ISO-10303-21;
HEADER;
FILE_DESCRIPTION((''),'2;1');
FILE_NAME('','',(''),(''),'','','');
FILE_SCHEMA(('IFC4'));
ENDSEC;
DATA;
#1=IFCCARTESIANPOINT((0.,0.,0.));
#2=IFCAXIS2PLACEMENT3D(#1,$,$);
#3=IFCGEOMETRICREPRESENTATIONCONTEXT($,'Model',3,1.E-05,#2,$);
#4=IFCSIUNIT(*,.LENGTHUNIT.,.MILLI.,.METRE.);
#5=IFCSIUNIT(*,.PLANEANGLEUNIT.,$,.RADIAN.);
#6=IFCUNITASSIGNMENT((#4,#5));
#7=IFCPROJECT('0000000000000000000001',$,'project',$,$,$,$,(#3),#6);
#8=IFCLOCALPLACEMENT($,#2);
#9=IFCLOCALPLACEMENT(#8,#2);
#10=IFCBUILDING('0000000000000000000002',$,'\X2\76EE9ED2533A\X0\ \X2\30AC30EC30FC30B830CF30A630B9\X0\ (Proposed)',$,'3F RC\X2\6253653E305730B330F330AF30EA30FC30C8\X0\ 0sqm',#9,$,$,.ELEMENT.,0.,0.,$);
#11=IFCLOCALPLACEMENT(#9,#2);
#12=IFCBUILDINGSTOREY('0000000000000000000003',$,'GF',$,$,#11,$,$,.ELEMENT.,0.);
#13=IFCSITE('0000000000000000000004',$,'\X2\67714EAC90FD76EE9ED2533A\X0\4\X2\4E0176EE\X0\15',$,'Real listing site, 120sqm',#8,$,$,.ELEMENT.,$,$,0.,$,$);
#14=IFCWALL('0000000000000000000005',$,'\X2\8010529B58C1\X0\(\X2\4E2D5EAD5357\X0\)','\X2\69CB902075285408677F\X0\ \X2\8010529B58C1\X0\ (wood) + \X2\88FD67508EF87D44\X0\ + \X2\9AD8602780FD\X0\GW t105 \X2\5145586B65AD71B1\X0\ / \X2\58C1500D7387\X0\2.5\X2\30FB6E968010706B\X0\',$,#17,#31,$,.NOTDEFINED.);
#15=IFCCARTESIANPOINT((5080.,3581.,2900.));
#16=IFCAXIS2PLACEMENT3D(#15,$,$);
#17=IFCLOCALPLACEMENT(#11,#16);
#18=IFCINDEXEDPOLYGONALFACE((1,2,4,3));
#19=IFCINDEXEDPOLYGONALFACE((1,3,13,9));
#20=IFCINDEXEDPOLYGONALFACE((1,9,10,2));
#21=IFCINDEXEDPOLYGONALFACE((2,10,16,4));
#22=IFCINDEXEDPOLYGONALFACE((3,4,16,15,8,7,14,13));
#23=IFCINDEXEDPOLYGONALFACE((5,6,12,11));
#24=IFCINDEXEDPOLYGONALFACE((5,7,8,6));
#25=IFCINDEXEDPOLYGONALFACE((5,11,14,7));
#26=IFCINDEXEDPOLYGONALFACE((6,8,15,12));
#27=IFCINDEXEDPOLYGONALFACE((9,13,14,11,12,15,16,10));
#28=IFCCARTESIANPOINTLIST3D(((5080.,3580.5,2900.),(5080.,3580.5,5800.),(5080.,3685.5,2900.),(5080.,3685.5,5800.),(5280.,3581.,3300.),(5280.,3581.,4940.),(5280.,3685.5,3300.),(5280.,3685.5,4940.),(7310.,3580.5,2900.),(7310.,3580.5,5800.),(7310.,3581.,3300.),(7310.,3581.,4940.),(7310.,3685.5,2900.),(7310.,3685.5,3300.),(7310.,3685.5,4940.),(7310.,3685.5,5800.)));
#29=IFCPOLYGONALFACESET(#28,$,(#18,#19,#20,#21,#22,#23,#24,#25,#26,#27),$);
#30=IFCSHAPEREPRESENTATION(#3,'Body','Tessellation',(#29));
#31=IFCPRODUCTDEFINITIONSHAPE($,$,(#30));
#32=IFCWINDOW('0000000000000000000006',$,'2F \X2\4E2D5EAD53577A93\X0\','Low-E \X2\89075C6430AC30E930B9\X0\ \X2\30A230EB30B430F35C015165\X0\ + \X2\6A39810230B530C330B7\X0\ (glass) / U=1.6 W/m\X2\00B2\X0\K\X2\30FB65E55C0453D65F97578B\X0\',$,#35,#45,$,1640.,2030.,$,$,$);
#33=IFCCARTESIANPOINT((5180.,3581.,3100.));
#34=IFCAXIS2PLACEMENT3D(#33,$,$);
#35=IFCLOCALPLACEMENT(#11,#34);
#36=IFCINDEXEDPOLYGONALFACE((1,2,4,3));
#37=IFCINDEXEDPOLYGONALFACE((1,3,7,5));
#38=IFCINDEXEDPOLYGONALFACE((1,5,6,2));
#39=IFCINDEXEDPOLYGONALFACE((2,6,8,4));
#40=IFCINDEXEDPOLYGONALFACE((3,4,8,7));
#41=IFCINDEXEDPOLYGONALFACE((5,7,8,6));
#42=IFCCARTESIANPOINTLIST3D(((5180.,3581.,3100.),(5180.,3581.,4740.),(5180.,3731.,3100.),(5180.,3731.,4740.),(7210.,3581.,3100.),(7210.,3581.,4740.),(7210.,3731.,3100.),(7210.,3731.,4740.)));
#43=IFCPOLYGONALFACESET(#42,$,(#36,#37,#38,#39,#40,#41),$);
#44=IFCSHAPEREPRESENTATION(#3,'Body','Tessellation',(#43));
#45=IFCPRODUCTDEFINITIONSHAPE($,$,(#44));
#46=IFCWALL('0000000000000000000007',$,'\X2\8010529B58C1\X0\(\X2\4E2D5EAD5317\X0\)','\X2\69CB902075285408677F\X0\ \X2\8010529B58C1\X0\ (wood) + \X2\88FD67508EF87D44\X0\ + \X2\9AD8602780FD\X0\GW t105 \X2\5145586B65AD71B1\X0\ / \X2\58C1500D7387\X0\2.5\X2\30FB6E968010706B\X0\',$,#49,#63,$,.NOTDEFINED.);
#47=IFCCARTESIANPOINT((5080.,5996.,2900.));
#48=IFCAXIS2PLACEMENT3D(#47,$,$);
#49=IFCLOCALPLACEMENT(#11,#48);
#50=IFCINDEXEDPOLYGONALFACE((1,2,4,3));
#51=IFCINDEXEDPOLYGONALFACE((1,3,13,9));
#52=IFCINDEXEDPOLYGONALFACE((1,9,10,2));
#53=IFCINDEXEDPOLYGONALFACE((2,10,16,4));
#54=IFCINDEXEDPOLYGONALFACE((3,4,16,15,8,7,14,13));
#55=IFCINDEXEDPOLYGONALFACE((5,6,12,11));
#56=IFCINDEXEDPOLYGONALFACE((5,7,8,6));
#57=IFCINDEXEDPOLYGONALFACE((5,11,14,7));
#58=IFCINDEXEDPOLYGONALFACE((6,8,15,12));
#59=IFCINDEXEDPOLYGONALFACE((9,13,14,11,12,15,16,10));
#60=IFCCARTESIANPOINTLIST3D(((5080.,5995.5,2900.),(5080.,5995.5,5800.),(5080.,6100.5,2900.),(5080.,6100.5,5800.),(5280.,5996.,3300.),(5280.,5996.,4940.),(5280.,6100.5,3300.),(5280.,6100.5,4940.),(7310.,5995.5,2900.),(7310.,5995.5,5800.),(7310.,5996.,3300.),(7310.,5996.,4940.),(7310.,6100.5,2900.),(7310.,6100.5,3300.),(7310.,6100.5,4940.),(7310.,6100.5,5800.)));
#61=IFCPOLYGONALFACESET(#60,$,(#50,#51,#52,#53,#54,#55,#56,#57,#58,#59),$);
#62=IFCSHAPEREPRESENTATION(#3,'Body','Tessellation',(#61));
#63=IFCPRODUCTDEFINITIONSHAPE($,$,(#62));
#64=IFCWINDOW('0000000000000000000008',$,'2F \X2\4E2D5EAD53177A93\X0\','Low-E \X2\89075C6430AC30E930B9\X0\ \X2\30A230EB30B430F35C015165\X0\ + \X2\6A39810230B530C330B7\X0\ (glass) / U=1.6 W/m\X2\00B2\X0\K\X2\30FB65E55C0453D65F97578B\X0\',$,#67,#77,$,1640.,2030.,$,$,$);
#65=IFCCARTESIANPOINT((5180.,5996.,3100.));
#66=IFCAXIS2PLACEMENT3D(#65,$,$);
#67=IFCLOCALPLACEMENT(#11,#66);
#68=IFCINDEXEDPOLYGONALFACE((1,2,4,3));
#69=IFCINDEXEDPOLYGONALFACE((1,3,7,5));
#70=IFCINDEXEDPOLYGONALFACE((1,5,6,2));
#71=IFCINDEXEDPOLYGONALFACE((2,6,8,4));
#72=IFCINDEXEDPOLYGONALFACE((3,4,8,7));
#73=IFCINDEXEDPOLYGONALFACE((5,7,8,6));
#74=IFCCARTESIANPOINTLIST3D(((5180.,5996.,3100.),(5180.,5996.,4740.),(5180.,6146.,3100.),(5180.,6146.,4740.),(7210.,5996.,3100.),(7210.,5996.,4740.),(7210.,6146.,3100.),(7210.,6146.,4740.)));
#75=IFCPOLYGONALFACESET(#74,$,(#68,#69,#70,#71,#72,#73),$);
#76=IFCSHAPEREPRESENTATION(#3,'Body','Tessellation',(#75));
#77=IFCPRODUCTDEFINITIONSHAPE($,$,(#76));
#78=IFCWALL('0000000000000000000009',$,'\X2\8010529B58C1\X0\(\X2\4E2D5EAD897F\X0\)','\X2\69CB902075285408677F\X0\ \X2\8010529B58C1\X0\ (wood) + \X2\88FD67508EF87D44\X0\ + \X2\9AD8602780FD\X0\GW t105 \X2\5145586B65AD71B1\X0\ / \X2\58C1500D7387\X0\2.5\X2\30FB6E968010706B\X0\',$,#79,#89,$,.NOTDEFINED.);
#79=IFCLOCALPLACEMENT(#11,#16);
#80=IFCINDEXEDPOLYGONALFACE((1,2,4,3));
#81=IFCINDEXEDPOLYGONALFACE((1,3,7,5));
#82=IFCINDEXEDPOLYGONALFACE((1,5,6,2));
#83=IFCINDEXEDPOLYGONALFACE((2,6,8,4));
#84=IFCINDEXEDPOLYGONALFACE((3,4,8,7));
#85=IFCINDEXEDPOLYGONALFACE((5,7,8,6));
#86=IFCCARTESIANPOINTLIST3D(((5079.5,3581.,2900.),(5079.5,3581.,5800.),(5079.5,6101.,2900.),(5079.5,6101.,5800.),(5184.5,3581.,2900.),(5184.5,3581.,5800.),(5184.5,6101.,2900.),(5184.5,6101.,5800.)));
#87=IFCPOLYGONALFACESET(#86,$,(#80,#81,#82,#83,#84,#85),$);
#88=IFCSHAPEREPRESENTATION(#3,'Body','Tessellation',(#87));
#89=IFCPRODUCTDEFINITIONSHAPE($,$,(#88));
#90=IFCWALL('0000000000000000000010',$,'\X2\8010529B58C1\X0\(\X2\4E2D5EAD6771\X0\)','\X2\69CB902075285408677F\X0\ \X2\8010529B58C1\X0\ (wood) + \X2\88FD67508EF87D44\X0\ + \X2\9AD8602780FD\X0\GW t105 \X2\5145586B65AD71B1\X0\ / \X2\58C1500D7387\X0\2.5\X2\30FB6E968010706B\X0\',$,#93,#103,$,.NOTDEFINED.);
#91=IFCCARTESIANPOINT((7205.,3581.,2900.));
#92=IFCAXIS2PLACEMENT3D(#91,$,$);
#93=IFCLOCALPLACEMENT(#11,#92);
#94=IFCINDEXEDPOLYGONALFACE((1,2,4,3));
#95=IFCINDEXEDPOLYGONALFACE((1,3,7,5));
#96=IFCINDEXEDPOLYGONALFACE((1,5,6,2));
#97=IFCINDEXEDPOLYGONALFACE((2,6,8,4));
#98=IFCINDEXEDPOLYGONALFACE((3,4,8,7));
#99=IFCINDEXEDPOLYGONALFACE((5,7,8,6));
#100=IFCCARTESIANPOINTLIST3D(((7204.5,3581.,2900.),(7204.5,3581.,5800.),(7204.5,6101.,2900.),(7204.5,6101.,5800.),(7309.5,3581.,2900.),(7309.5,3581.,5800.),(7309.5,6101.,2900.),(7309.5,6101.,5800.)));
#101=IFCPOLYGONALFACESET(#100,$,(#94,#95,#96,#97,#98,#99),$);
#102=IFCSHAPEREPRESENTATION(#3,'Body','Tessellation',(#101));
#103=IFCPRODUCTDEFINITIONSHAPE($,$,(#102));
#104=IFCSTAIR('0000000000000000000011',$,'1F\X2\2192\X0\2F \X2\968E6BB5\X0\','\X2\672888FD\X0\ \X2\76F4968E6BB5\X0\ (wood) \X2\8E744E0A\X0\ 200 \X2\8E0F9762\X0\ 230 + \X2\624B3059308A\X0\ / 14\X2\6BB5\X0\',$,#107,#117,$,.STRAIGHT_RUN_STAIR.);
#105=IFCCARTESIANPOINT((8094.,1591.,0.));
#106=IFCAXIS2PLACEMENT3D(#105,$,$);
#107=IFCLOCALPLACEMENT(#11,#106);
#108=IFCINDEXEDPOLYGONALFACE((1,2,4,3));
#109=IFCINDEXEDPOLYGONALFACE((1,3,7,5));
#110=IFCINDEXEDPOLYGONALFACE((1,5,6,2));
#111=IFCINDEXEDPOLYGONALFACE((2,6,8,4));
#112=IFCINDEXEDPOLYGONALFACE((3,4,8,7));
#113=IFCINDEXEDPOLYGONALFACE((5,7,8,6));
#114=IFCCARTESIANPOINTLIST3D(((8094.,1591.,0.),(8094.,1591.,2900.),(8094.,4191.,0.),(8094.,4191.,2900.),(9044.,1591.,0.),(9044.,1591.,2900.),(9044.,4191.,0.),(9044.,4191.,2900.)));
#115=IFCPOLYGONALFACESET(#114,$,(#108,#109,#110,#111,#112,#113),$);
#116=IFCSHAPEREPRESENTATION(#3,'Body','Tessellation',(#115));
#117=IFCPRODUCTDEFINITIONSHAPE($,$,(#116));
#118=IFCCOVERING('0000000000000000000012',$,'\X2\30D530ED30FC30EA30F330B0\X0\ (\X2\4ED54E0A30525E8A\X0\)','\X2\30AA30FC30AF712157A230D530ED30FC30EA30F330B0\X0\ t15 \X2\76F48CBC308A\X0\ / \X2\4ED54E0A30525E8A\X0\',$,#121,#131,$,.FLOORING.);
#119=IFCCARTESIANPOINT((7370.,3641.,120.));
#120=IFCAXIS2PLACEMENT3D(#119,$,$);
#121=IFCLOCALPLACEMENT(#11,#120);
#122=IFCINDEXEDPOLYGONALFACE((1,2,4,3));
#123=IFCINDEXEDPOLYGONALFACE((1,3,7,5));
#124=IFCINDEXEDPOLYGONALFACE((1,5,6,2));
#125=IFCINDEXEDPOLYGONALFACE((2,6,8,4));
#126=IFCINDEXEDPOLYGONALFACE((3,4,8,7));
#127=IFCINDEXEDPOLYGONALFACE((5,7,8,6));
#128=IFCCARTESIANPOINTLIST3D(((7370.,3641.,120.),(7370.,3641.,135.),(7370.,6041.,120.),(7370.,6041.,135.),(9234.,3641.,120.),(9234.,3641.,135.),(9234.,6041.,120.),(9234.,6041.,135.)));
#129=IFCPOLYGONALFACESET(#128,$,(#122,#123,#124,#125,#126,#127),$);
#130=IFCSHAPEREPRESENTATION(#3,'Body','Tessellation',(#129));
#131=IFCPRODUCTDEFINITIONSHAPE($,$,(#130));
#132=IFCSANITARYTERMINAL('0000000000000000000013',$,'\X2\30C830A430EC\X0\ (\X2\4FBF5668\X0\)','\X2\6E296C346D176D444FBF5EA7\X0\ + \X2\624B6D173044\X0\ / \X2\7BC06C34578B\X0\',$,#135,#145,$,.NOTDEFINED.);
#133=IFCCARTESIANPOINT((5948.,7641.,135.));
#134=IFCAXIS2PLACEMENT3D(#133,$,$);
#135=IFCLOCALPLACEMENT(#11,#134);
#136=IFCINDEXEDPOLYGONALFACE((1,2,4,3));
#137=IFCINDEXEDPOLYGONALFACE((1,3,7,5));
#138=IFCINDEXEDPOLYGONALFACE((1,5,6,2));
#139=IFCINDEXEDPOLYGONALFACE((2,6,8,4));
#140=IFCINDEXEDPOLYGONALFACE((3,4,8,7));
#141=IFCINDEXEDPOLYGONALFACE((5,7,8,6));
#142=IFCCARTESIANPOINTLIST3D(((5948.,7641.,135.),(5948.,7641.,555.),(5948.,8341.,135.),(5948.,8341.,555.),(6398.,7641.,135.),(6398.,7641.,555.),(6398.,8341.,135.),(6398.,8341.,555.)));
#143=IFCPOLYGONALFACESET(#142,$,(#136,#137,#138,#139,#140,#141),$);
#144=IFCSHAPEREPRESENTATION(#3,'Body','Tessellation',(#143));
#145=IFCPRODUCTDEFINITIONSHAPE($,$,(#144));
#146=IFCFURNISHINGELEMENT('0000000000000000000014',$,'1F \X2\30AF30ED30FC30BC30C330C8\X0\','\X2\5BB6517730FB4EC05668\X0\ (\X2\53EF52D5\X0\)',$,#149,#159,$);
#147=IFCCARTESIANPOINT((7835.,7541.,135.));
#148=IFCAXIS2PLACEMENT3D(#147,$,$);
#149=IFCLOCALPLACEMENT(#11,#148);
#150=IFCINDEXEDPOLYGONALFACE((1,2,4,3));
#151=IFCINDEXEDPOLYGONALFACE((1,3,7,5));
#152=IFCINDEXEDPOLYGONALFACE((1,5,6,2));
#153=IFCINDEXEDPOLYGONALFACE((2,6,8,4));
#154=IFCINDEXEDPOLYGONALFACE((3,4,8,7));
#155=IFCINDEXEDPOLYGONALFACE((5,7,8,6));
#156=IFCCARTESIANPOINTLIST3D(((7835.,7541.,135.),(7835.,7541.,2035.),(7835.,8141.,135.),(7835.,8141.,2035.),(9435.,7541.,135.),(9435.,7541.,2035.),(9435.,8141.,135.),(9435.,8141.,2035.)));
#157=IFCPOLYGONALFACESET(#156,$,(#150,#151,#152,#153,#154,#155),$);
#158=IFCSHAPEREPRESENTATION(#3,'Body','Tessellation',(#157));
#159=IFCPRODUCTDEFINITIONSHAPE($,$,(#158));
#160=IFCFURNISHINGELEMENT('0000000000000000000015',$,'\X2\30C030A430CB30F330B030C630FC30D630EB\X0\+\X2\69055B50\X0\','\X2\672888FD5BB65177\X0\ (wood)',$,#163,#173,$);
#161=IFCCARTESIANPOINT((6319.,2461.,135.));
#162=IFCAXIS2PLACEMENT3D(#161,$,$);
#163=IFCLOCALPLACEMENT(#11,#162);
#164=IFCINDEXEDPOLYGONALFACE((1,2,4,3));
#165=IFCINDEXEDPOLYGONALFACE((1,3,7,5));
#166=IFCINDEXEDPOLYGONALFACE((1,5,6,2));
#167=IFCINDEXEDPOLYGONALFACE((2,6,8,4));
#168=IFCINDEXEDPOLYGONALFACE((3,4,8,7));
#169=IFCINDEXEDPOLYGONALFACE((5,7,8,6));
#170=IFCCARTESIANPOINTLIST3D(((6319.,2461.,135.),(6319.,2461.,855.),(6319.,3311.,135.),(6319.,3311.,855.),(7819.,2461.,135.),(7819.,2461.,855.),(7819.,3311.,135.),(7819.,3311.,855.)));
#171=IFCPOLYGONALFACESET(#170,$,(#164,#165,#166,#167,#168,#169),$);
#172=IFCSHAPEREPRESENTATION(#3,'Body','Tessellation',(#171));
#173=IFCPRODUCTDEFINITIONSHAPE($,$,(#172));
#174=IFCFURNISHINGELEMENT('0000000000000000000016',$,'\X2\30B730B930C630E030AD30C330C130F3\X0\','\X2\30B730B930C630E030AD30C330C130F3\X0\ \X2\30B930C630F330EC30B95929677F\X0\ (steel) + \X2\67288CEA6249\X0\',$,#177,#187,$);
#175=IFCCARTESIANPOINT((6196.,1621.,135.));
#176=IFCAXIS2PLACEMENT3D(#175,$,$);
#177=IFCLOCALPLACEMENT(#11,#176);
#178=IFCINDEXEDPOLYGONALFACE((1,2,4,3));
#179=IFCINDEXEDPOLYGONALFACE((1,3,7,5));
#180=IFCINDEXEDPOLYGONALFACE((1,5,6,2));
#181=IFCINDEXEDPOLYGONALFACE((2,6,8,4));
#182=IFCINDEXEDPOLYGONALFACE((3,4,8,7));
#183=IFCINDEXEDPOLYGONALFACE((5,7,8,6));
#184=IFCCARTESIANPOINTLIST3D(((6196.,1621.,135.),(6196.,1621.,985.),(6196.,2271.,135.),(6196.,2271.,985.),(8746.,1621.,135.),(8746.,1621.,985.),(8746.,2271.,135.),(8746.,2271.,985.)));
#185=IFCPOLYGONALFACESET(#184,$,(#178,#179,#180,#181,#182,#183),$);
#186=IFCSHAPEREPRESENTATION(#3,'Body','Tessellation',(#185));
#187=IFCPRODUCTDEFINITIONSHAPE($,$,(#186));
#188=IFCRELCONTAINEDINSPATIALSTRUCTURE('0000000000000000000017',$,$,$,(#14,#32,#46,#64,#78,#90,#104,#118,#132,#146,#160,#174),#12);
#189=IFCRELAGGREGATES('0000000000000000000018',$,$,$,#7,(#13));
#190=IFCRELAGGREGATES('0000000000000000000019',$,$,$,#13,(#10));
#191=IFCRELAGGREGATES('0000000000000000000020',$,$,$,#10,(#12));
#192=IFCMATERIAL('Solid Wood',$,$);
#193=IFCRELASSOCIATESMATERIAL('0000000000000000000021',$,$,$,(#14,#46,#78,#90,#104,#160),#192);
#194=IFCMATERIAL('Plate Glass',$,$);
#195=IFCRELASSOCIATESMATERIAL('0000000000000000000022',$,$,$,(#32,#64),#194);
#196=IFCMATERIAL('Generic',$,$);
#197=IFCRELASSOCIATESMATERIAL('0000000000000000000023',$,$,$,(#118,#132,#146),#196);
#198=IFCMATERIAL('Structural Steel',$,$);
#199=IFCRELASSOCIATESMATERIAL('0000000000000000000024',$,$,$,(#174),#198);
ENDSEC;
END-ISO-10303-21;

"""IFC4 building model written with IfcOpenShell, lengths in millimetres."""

from ifc_helpers import new_model, si_unit, frame, frame_2d, origin, place, context, project, spatial, rectangle, extrude, material, element, fill, save


model = new_model("IFC4")

# Units and contexts
model_context = context("Model", 3, precision=1e-05, world=origin())
ifc_project = project(units=[si_unit("LENGTHUNIT", "METRE", prefix="MILLI"), si_unit("PLANEANGLEUNIT", "RADIAN")], contexts=[model_context])

# Site, building, storey
site_placement = place(None, origin())
site = spatial("IfcSite", under=ifc_project, at=site_placement, Name="東京都目黒区4丁目15", ObjectType="Real listing site, 120sqm", CompositionType="ELEMENT", RefElevation=0.0)
building_placement = place(site_placement, origin())
building = spatial("IfcBuilding", under=site, at=building_placement, Name="目黒区 ガレージハウス (Proposed)", ObjectType="3F RC打放しコンクリート 0sqm", CompositionType="ELEMENT", ElevationOfRefHeight=0.0, ElevationOfTerrain=0.0)
storey_placement = place(building_placement, origin())
storey = spatial("IfcBuildingStorey", under=building, at=storey_placement, Name="GF", CompositionType="ELEMENT", Elevation=0.0)

# Shared definitions
ifc_material_1 = material(Name="Solid Wood")

# Shared definitions
ifc_material_2 = material(Name="Plate Glass")

# Walls, openings, windows
wall_1_placement = place(storey_placement, frame((5080.0, 3581.0, 2900.0)))
wall_1 = element("IfcWall", 1, at=wall_1_placement, inside=storey, material=ifc_material_1, Name="耐力壁(中庭南)", Description="構造用合板 耐力壁 (wood) + 製材軸組 + 高性能GW t105 充填断熱 / 壁倍率2.5・準耐火", PredefinedType="NOTDEFINED", context=model_context, shape_type="SweptSolid", body=[
    extrude(rectangle(XDim=2230.0, YDim=105.0, at=frame_2d((1115.0, 52.0))), frame((5080.0, 3581.0, 2900.0)), (0.0, 0.0, 1.0), 2900.0),
])
opening_1_placement = place(storey_placement, frame((5180.0, 3581.0, 3100.0)))
opening_1 = element("IfcOpeningElement", 2, at=opening_1_placement, cuts=wall_1, PredefinedType="NOTDEFINED", context=model_context, shape_type="SweptSolid", body=[
    extrude(rectangle(XDim=2030.0, YDim=150.0, at=frame_2d((1015.0, 75.0))), frame((5180.0, 3581.0, 3100.0)), (0.0, 0.0, 1.0), 1640.0),
])
window_1_placement = place(storey_placement, frame((5180.0, 3581.0, 3100.0)))
window_1 = element("IfcWindow", 3, at=window_1_placement, inside=storey, material=ifc_material_2, Name="2F 中庭南窓", Description="Low-E 複層ガラス アルゴン封入 + 樹脂サッシ (glass) / U=1.6 W/m²K・日射取得型", OverallHeight=1640.0, OverallWidth=2030.0, context=model_context, shape_type="SweptSolid", body=[
    extrude(rectangle(XDim=2030.0, YDim=150.0, at=frame_2d((1015.0, 75.0))), frame((5180.0, 3581.0, 3100.0)), (0.0, 0.0, 1.0), 1640.0),
])
fill(opening_1, window_1)
wall_2_placement = place(storey_placement, frame((5080.0, 5996.0, 2900.0)))
wall_2 = element("IfcWall", 4, at=wall_2_placement, inside=storey, material=ifc_material_1, Name="耐力壁(中庭北)", Description="構造用合板 耐力壁 (wood) + 製材軸組 + 高性能GW t105 充填断熱 / 壁倍率2.5・準耐火", PredefinedType="NOTDEFINED", context=model_context, shape_type="SweptSolid", body=[
    extrude(rectangle(XDim=2230.0, YDim=105.0, at=frame_2d((1115.0, 52.0))), frame((5080.0, 5996.0, 2900.0)), (0.0, 0.0, 1.0), 2900.0),
])
opening_2_placement = place(storey_placement, frame((5180.0, 5996.0, 3100.0)))
opening_2 = element("IfcOpeningElement", 5, at=opening_2_placement, cuts=wall_2, PredefinedType="NOTDEFINED", context=model_context, shape_type="SweptSolid", body=[
    extrude(rectangle(XDim=2030.0, YDim=150.0, at=frame_2d((1015.0, 75.0))), frame((5180.0, 5996.0, 3100.0)), (0.0, 0.0, 1.0), 1640.0),
])
window_2_placement = place(storey_placement, frame((5180.0, 5996.0, 3100.0)))
window_2 = element("IfcWindow", 6, at=window_2_placement, inside=storey, material=ifc_material_2, Name="2F 中庭北窓", Description="Low-E 複層ガラス アルゴン封入 + 樹脂サッシ (glass) / U=1.6 W/m²K・日射取得型", OverallHeight=1640.0, OverallWidth=2030.0, context=model_context, shape_type="SweptSolid", body=[
    extrude(rectangle(XDim=2030.0, YDim=150.0, at=frame_2d((1015.0, 75.0))), frame((5180.0, 5996.0, 3100.0)), (0.0, 0.0, 1.0), 1640.0),
])
fill(opening_2, window_2)

# Walls
wall_3_placement = place(storey_placement, frame((5080.0, 3581.0, 2900.0)))
element("IfcWall", 7, at=wall_3_placement, inside=storey, material=ifc_material_1, Name="耐力壁(中庭西)", Description="構造用合板 耐力壁 (wood) + 製材軸組 + 高性能GW t105 充填断熱 / 壁倍率2.5・準耐火", PredefinedType="NOTDEFINED", context=model_context, shape_type="SweptSolid", body=[
    extrude(rectangle(XDim=105.0, YDim=2520.0, at=frame_2d((52.0, 1260.0))), frame((5080.0, 3581.0, 2900.0)), (0.0, 0.0, 1.0), 2900.0),
])
wall_4_placement = place(storey_placement, frame((7205.0, 3581.0, 2900.0)))
element("IfcWall", 8, at=wall_4_placement, inside=storey, material=ifc_material_1, Name="耐力壁(中庭東)", Description="構造用合板 耐力壁 (wood) + 製材軸組 + 高性能GW t105 充填断熱 / 壁倍率2.5・準耐火", PredefinedType="NOTDEFINED", context=model_context, shape_type="SweptSolid", body=[
    extrude(rectangle(XDim=105.0, YDim=2520.0, at=frame_2d((52.0, 1260.0))), frame((7205.0, 3581.0, 2900.0)), (0.0, 0.0, 1.0), 2900.0),
])

# Stair
stair_placement = place(storey_placement, frame((8094.0, 1591.0, 0.0)))
element("IfcStair", 9, at=stair_placement, inside=storey, material=ifc_material_1, Name="1F→2F 階段", Description="木製 直階段 (wood) 蹴上 200 踏面 230 + 手すり / 14段", PredefinedType="STRAIGHT_RUN_STAIR", context=model_context, shape_type="SweptSolid", body=[
    extrude(rectangle(XDim=950.0, YDim=2600.0, at=frame_2d((475.0, 1300.0))), frame((8094.0, 1591.0, 0.0)), (0.0, 0.0, 1.0), 2900.0),
])

# Covering
ifc_material_3 = material(Name="Generic")
covering_placement = place(storey_placement, frame((7370.0, 3641.0, 120.0)))
element("IfcCovering", 10, at=covering_placement, inside=storey, material=ifc_material_3, Name="フローリング (仕上げ床)", Description="オーク無垢フローリング t15 直貼り / 仕上げ床", PredefinedType="FLOORING", context=model_context, shape_type="SweptSolid", body=[
    extrude(rectangle(XDim=1864.0, YDim=2400.0, at=frame_2d((932.0, 1200.0))), frame((7370.0, 3641.0, 120.0)), (0.0, 0.0, 1.0), 15.0),
])

# Sanitary terminal
sanitary_terminal_placement = place(storey_placement, frame((5948.0, 7641.0, 135.0)))
element("IfcSanitaryTerminal", 11, at=sanitary_terminal_placement, inside=storey, material=ifc_material_3, Name="トイレ (便器)", Description="温水洗浄便座 + 手洗い / 節水型", PredefinedType="NOTDEFINED", context=model_context, shape_type="SweptSolid", body=[
    extrude(rectangle(XDim=450.0, YDim=700.0, at=frame_2d((225.0, 350.0))), frame((5948.0, 7641.0, 135.0)), (0.0, 0.0, 1.0), 420.0),
])

# Furnishing elements
furnishing_1_placement = place(storey_placement, frame((7835.0, 7541.0, 135.0)))
element("IfcFurnishingElement", 12, at=furnishing_1_placement, inside=storey, material=ifc_material_3, Name="1F クローゼット", Description="家具・什器 (可動)", context=model_context, shape_type="SweptSolid", body=[
    extrude(rectangle(XDim=1600.0, YDim=600.0, at=frame_2d((800.0, 300.0))), frame((7835.0, 7541.0, 135.0)), (0.0, 0.0, 1.0), 1900.0),
])
furnishing_2_placement = place(storey_placement, frame((6319.0, 2461.0, 135.0)))
element("IfcFurnishingElement", 13, at=furnishing_2_placement, inside=storey, material=ifc_material_1, Name="ダイニングテーブル+椅子", Description="木製家具 (wood)", context=model_context, shape_type="SweptSolid", body=[
    extrude(rectangle(XDim=1500.0, YDim=850.0, at=frame_2d((750.0, 425.0))), frame((6319.0, 2461.0, 135.0)), (0.0, 0.0, 1.0), 720.0),
])
ifc_material_4 = material(Name="Structural Steel")
furnishing_3_placement = place(storey_placement, frame((6196.0, 1621.0, 135.0)))
element("IfcFurnishingElement", 14, at=furnishing_3_placement, inside=storey, material=ifc_material_4, Name="システムキッチン", Description="システムキッチン ステンレス天板 (steel) + 木質扉", context=model_context, shape_type="SweptSolid", body=[
    extrude(rectangle(XDim=2550.0, YDim=650.0, at=frame_2d((1275.0, 325.0))), frame((6196.0, 1621.0, 135.0)), (0.0, 0.0, 1.0), 850.0),
])

save(model, "model.ifc")
